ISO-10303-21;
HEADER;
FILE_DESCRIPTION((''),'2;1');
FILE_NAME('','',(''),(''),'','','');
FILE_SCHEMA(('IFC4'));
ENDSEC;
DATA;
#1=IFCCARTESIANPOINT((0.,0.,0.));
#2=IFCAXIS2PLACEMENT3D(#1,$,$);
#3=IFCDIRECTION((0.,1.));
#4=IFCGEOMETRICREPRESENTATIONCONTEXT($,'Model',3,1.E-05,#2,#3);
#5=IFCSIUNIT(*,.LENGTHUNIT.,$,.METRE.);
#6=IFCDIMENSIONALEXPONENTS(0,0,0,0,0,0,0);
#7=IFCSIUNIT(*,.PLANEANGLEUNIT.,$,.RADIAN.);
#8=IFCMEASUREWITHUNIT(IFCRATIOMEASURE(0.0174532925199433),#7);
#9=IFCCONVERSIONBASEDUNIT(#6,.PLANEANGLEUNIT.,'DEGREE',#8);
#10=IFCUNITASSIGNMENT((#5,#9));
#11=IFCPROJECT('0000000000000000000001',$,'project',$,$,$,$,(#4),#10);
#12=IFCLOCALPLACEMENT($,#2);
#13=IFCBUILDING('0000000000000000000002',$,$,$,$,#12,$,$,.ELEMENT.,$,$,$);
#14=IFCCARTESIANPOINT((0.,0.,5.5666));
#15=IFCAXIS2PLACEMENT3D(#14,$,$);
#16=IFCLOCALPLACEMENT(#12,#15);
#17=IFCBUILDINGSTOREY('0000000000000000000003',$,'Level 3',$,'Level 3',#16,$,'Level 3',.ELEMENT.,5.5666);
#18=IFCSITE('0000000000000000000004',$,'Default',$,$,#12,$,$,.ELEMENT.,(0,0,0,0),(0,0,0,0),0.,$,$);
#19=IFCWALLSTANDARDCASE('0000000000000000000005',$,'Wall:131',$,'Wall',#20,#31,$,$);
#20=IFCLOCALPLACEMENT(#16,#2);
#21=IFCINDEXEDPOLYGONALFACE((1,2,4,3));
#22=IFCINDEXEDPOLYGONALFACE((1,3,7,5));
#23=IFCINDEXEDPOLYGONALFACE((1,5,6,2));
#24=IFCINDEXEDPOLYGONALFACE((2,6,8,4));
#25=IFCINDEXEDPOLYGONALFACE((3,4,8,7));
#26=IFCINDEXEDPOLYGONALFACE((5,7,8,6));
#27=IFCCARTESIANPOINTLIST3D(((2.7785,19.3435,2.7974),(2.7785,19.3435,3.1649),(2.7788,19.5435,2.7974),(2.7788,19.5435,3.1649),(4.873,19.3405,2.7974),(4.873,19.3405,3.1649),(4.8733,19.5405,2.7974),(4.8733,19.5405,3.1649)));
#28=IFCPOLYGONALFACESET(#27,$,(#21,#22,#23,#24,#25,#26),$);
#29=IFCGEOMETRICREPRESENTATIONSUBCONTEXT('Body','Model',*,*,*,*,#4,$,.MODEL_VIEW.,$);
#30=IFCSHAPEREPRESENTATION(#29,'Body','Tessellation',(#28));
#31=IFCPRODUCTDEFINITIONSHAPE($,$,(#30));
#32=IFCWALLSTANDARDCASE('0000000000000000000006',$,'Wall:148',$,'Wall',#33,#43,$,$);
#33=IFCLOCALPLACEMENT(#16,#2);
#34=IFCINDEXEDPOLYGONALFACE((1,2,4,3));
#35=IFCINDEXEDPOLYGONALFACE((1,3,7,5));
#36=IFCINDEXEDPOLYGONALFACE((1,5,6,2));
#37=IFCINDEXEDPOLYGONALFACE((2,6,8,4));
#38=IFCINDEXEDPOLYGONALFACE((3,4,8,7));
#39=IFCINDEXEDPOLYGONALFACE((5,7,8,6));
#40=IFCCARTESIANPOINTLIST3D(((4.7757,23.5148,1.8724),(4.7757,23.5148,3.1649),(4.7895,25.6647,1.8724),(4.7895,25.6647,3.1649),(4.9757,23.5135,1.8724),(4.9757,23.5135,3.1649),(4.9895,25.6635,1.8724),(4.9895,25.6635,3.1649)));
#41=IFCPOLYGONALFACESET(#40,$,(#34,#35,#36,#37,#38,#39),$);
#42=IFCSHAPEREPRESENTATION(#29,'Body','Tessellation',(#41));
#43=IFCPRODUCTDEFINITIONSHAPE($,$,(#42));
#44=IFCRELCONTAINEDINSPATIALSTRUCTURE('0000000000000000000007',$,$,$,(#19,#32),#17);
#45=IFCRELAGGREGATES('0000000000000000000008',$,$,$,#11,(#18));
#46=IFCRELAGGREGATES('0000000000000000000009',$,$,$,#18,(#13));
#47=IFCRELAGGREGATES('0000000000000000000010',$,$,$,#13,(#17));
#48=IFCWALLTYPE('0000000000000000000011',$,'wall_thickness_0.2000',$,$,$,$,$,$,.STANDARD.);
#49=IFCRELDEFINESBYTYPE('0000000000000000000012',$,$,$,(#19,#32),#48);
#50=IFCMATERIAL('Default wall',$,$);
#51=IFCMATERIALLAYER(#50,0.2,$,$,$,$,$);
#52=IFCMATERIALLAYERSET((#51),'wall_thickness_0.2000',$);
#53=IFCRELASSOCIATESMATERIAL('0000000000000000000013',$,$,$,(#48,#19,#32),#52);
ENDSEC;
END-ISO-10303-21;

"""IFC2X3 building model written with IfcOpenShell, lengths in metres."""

from ifc_helpers import new_model, entity, si_unit, converted_unit, direction, frame, origin, place, context, subcontext, project, spatial, polyline, outline, extrude, material, layer, layer_set, layer_usage, type_object, element, save


model = new_model("IFC2X3")

# Units and contexts
model_context = context("Model", 3, precision=1e-05, world=origin(), true_north=direction((0.0, 1.0)))
body_context = subcontext(model_context, "Body", "Model", "MODEL_VIEW")
ifc_project = project(units=[si_unit("LENGTHUNIT", "METRE"), converted_unit("PLANEANGLEUNIT", "DEGREE", entity("IfcRatioMeasure", 0.0174532925199433), si_unit("PLANEANGLEUNIT", "RADIAN"), dimensions=[0, 0, 0, 0, 0, 0, 0])], contexts=[model_context])

# Site, building, storey
placement_1 = place(None, origin())
site = spatial("IfcSite", under=ifc_project, at=placement_1, Name="Default", CompositionType="ELEMENT", RefLatitude=(0, 0, 0, 0), RefLongitude=(0, 0, 0, 0), RefElevation=0.0)
building = spatial("IfcBuilding", under=site, at=placement_1, CompositionType="ELEMENT")
storey_placement = place(placement_1, frame((0.0, 0.0, 5.5666)))
storey = spatial("IfcBuildingStorey", under=building, at=storey_placement, Name="Level 3", ObjectType="Level 3", LongName="Level 3", CompositionType="ELEMENT", Elevation=5.5666)

# Shared definitions
ifc_material_1 = material(Name="Default wall")

# Shared definitions
ifc_layer_1 = layer(ifc_material_1, 0.2)
ifc_layer_set_1 = layer_set([ifc_layer_1], Name="wall_thickness_0.2000")
ifc_layer_usage_1 = layer_usage(ifc_layer_set_1, "AXIS2", "POSITIVE", -0.1)
wall_type_1 = type_object("IfcWallType", Name="wall_thickness_0.2000", PredefinedType="STANDARD", material=ifc_layer_set_1)

# Walls
placement_2 = place(placement_1, frame((0.0, 0.0, 8.364)))
wall_1_placement = place(placement_2, frame((2.7786, 19.4435, 0.0), z_axis=(0.0, 0.0, 1.0), x_axis=(0.999999, -0.001464, 0.0)))
element("IfcWallStandardCase", 1, at=wall_1_placement, inside=storey, type_object=wall_type_1, material=ifc_layer_usage_1, Name="Wall:131", ObjectType="Wall", context=body_context, shape_type="SweptSolid", body=[
    extrude(outline(polyline([(2.0945, -0.1), (2.0945, 0.1), (0.0, 0.1), (0.0, -0.1), (2.0945, -0.1)])), origin(), (0.0, 0.0, 1.0), 0.3675),
])
placement_3 = place(placement_1, frame((0.0, 0.0, 7.439)))
wall_2_placement = place(placement_3, frame((4.8895, 25.6641, 0.0), z_axis=(0.0, 0.0, 1.0), x_axis=(-0.006417, -0.999979, 0.0)))
element("IfcWallStandardCase", 2, at=wall_2_placement, inside=storey, type_object=wall_type_1, material=ifc_layer_usage_1, Name="Wall:148", ObjectType="Wall", context=body_context, shape_type="SweptSolid", body=[
    extrude(outline(polyline([(2.15, -0.1), (2.15, 0.1), (0.0, 0.1), (0.0, -0.1), (2.15, -0.1)])), origin(), (0.0, 0.0, 1.0), 1.2925),
])

save(model, "model.ifc")
